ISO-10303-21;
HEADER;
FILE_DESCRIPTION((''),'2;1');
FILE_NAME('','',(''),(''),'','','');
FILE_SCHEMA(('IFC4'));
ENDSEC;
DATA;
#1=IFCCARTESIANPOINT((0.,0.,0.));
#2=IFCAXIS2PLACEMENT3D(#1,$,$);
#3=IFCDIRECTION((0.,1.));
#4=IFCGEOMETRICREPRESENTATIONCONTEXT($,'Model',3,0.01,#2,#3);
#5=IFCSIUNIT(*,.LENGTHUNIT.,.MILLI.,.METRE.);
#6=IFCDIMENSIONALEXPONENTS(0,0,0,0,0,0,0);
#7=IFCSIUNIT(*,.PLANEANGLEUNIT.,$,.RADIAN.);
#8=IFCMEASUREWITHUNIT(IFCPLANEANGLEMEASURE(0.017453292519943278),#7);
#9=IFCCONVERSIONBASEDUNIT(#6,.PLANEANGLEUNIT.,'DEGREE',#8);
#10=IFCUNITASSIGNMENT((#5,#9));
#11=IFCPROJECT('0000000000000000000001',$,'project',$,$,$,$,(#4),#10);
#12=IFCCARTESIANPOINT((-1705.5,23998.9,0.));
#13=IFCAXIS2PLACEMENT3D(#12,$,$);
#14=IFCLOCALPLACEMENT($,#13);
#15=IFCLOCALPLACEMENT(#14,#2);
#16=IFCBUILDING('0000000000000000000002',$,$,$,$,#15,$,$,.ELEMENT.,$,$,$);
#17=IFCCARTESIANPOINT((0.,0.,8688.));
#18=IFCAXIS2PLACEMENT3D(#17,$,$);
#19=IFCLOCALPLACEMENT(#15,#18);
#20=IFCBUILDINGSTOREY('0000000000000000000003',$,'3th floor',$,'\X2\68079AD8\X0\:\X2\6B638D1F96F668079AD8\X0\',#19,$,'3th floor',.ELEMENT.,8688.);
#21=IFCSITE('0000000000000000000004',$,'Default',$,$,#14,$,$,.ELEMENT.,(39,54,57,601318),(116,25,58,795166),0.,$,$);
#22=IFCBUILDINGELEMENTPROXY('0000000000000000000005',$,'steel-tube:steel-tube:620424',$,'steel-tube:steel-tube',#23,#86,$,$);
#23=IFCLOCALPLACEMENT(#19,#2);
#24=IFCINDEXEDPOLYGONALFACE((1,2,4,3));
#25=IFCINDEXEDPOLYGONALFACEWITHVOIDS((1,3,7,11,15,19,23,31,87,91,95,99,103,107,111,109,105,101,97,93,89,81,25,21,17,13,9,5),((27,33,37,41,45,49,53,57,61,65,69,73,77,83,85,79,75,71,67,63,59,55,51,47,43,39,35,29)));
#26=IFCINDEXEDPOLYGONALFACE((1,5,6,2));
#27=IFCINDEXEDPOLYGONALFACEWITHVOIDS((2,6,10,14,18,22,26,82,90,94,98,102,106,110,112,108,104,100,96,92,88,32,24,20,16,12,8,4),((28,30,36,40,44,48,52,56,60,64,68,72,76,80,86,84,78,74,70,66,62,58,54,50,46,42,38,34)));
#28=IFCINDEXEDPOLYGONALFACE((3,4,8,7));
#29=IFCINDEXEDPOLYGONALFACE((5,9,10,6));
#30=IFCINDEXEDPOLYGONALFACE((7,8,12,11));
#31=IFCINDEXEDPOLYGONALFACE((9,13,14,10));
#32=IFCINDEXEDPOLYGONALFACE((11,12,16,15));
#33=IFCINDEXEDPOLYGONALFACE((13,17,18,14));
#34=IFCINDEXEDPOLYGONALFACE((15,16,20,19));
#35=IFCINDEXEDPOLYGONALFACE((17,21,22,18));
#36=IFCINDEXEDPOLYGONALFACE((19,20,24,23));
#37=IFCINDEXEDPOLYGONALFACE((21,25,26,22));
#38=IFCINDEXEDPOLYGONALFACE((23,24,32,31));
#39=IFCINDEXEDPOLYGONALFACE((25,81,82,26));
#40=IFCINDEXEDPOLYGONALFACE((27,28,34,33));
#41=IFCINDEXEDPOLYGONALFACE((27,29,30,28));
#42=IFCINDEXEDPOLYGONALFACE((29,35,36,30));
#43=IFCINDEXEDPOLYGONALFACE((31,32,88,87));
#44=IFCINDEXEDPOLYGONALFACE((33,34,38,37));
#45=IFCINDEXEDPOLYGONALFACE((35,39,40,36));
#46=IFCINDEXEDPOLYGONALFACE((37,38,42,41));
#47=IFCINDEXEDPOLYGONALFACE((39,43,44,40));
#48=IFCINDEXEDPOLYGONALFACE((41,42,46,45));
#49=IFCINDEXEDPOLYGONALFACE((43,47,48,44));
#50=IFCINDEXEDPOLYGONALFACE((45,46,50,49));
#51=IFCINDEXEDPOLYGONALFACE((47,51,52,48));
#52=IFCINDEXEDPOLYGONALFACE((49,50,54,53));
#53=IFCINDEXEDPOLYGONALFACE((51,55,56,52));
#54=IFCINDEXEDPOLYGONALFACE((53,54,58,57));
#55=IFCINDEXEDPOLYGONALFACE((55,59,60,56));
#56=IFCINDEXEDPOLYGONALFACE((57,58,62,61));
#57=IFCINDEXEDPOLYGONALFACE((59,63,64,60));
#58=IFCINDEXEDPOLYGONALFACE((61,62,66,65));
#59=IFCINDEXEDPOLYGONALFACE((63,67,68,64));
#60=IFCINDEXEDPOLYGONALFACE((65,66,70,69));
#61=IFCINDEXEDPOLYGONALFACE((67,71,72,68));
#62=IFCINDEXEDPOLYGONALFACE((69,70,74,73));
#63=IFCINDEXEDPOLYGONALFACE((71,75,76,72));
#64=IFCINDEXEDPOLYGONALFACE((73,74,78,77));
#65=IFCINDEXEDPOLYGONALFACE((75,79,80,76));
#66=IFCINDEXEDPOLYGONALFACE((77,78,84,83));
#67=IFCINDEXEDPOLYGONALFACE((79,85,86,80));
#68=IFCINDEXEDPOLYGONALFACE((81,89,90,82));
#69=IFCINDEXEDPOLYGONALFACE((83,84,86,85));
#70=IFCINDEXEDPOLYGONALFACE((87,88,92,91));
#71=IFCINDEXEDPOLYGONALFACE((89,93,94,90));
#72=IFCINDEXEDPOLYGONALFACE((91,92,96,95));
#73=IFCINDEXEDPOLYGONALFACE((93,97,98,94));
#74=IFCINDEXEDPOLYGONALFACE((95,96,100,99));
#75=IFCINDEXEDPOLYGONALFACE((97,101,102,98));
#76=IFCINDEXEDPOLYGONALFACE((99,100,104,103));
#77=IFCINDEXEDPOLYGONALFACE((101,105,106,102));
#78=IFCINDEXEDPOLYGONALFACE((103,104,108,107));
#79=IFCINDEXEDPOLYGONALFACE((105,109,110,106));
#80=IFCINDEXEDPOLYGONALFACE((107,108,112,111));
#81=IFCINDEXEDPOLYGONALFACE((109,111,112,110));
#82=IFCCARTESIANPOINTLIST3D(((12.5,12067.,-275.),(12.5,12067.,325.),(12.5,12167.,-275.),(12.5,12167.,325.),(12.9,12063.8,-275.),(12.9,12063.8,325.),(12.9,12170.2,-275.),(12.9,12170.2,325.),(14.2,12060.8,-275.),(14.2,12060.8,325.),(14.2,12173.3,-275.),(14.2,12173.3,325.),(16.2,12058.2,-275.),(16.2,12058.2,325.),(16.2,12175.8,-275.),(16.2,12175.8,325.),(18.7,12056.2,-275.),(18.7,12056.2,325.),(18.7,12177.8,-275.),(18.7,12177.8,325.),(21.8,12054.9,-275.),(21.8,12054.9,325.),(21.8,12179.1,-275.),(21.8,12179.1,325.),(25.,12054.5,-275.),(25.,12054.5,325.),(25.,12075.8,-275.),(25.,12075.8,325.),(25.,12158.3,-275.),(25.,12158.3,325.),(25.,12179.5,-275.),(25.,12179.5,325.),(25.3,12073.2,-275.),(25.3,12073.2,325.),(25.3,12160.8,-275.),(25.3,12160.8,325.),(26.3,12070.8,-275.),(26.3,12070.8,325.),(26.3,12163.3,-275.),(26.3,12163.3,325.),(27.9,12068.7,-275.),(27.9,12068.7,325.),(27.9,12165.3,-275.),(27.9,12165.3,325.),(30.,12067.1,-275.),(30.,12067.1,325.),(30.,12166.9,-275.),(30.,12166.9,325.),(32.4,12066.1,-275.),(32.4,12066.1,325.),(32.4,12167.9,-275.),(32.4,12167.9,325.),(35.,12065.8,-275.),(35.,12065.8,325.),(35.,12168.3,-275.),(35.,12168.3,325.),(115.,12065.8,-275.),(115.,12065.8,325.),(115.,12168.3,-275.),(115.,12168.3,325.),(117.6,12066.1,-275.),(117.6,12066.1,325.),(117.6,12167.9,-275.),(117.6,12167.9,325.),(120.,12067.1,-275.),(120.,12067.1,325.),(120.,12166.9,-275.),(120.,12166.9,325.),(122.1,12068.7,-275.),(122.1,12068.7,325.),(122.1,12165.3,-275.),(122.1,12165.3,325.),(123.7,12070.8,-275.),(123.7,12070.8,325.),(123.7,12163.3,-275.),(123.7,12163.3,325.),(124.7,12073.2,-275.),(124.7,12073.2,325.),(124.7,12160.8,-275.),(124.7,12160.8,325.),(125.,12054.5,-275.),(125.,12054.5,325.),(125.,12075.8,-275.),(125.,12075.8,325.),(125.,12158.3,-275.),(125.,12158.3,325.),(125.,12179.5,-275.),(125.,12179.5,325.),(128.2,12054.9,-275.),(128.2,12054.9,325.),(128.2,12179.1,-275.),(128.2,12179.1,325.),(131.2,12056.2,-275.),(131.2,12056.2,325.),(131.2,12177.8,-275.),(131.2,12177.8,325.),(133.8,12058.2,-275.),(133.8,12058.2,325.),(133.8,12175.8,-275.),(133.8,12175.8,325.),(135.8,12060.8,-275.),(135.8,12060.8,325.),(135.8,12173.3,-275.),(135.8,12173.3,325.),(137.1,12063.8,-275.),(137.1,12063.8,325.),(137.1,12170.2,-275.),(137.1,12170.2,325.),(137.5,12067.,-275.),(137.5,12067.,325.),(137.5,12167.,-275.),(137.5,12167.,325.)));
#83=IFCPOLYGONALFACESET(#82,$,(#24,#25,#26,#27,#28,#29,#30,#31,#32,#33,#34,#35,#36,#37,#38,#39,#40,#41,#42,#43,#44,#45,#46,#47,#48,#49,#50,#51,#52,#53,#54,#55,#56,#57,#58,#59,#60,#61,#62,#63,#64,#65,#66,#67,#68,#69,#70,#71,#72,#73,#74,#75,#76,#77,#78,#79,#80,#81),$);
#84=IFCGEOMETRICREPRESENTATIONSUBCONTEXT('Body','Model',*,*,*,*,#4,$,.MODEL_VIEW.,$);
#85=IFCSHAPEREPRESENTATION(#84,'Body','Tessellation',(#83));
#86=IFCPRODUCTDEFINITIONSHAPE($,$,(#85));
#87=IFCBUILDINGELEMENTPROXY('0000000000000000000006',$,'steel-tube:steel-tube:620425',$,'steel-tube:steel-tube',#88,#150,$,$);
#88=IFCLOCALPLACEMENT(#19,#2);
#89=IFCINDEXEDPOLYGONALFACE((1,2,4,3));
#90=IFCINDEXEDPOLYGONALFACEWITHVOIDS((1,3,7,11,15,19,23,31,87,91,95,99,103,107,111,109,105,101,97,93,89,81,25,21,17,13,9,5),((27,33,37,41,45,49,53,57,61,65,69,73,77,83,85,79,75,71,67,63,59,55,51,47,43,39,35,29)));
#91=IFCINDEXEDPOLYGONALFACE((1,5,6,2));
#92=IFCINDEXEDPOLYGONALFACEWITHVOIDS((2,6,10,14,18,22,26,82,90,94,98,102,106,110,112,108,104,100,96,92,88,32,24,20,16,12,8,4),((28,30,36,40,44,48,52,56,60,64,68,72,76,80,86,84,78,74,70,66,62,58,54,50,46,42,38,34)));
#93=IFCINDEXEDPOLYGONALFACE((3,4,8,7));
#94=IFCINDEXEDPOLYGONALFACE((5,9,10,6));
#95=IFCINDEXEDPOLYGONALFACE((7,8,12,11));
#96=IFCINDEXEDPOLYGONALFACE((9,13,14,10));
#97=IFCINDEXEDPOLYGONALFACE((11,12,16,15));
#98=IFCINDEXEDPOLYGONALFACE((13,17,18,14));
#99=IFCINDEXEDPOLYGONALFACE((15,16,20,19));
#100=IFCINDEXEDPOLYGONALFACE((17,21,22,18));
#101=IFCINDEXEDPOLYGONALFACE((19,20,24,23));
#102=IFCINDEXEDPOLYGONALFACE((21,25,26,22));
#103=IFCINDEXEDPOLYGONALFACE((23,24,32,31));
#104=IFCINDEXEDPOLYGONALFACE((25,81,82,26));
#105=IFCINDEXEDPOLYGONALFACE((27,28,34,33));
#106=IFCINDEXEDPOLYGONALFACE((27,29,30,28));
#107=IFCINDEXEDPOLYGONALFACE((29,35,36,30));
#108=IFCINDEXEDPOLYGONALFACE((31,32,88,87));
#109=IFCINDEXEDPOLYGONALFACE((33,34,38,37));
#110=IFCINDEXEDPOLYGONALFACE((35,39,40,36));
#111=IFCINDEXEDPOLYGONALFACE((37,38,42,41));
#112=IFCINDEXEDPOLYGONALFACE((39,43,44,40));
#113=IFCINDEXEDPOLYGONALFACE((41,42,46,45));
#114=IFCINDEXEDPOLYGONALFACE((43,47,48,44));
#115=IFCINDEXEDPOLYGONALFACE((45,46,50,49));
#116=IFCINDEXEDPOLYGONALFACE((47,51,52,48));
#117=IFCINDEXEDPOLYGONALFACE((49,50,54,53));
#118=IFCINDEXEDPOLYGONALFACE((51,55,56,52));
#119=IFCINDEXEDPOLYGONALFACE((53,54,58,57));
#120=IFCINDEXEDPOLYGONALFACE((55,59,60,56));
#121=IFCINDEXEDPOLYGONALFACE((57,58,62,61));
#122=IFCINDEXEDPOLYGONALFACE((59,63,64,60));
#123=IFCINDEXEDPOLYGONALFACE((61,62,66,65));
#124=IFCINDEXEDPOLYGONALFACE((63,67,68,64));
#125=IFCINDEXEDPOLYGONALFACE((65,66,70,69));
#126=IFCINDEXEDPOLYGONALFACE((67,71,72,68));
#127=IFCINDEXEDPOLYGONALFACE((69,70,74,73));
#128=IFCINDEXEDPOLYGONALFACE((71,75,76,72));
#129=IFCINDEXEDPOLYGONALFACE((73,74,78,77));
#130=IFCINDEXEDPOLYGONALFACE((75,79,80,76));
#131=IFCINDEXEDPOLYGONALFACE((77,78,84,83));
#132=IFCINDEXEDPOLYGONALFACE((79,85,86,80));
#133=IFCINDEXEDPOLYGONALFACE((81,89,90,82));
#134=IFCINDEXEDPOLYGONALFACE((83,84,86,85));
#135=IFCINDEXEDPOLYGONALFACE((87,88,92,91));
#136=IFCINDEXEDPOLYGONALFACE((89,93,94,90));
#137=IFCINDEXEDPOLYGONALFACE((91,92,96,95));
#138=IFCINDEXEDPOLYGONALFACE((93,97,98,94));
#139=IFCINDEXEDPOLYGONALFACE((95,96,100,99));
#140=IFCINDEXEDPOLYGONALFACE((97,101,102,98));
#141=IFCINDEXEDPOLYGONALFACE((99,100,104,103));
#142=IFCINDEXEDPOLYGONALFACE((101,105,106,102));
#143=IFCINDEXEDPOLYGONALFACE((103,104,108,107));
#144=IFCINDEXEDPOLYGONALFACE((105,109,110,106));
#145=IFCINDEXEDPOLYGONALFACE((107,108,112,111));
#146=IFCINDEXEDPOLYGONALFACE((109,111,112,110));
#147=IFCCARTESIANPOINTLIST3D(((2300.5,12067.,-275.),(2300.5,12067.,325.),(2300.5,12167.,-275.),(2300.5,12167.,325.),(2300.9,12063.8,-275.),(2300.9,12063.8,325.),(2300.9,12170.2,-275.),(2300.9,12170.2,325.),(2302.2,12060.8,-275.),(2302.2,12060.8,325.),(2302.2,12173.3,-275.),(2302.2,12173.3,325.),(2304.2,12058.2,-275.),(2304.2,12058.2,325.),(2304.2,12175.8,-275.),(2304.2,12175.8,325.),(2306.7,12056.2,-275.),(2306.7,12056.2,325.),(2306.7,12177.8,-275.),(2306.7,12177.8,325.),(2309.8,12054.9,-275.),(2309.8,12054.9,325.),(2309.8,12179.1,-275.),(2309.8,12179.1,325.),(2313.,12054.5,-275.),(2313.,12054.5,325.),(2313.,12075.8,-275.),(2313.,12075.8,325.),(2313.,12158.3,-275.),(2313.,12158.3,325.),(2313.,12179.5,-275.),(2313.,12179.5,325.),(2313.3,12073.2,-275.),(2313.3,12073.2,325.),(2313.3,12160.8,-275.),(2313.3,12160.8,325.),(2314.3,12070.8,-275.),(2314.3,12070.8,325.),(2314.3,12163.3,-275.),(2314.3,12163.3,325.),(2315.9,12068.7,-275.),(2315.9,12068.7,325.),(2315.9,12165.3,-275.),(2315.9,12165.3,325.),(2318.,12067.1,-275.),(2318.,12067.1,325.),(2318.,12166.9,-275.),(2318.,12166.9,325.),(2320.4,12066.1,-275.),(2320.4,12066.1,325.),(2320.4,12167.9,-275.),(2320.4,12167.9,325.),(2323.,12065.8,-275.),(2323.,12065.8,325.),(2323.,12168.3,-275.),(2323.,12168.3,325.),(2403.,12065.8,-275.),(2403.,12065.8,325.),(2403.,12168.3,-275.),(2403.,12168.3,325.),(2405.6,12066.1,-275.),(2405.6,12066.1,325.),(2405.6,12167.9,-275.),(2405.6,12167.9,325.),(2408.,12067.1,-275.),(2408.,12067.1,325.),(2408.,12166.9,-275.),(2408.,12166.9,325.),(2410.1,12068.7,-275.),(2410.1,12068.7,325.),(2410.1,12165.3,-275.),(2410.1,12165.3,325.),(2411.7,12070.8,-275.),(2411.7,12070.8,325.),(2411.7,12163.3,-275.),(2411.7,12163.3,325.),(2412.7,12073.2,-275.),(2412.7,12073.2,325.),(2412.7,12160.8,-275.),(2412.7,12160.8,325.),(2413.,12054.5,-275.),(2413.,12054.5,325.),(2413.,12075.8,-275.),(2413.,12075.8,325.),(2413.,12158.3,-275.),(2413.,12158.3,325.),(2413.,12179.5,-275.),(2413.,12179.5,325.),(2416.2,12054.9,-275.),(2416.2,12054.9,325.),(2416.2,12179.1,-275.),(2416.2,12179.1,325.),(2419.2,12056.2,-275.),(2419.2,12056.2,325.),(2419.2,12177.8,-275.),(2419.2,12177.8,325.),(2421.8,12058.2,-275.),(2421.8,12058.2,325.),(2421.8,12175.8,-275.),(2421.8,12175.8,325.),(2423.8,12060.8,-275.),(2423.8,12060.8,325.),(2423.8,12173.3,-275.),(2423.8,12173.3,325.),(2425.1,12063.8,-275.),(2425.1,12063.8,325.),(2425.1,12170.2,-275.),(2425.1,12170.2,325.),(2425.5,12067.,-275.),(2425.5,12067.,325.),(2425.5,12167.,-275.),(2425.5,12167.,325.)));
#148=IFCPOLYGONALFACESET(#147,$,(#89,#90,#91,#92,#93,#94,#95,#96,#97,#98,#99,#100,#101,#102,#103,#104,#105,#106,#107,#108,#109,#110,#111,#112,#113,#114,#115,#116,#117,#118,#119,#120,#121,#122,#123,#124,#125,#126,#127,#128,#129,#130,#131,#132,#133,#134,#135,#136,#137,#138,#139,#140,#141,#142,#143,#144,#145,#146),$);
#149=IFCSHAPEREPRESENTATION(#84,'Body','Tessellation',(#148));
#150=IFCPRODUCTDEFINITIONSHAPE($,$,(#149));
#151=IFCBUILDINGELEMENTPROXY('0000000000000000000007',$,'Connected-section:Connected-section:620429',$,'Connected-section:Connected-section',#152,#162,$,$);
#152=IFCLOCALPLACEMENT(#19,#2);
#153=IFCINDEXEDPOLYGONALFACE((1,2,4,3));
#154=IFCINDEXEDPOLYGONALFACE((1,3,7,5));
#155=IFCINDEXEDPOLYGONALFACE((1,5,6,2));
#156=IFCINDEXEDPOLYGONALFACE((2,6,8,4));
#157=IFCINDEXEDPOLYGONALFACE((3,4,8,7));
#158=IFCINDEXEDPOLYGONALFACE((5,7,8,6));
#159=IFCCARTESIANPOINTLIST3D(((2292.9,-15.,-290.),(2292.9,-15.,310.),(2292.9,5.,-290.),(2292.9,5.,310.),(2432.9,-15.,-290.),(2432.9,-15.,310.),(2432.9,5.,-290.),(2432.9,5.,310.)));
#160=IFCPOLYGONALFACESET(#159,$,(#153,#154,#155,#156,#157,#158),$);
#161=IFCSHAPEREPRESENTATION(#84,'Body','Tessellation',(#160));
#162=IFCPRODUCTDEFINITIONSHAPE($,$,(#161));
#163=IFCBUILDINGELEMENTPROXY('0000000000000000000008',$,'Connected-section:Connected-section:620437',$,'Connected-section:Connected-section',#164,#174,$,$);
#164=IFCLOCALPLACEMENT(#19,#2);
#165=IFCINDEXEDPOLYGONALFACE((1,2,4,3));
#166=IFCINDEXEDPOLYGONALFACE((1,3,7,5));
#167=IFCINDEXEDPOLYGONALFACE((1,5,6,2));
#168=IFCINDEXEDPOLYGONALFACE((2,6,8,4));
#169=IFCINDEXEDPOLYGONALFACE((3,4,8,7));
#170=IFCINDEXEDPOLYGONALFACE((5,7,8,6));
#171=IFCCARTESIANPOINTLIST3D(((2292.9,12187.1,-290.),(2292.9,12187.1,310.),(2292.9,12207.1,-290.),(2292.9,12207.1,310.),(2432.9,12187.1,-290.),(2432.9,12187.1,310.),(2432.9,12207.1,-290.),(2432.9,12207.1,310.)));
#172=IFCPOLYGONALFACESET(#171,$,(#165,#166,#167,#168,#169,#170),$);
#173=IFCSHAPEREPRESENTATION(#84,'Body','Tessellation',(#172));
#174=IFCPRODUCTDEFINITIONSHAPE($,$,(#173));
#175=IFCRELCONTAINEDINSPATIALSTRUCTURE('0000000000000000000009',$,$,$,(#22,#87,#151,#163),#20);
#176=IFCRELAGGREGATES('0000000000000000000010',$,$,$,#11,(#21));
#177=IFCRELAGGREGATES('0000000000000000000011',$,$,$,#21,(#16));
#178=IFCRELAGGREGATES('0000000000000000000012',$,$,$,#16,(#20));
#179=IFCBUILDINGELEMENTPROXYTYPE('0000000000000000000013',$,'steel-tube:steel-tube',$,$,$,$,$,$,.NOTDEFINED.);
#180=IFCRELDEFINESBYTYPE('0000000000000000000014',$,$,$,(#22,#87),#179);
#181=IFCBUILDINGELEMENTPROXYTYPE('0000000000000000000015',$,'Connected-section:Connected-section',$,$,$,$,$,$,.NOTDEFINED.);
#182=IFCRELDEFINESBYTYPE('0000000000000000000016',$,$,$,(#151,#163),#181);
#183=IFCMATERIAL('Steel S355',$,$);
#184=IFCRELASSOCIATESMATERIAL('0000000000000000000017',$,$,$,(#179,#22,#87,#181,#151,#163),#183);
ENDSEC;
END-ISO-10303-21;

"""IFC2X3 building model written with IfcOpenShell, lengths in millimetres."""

from ifc_helpers import new_model, entity, si_unit, converted_unit, direction, frame, frame_2d, origin, place, context, subcontext, project, spatial, polyline, circle_curve, parameter, trimmed, segment, composite_curve, rectangle, outline, extrude, source, transform, mapped, material, type_object, type_shapes, element, save


model = new_model("IFC2X3")

# Units and contexts
model_context = context("Model", 3, precision=0.01, world=origin(), true_north=direction((0.0, 1.0)))
body_context = subcontext(model_context, "Body", "Model", "MODEL_VIEW")
ifc_project = project(units=[si_unit("LENGTHUNIT", "METRE", prefix="MILLI"), converted_unit("PLANEANGLEUNIT", "DEGREE", entity("IfcPlaneAngleMeasure", 0.017453292519943278), si_unit("PLANEANGLEUNIT", "RADIAN"), dimensions=[0, 0, 0, 0, 0, 0, 0])], contexts=[model_context])

# Site, building, storey
site_placement = place(None, frame((-1705.5, 23998.9, 0.0)))
site = spatial("IfcSite", under=ifc_project, at=site_placement, Name="Default", CompositionType="ELEMENT", RefLatitude=(39, 54, 57, 601318), RefLongitude=(116, 25, 58, 795166), RefElevation=0.0)
building_placement = place(site_placement, origin())
building = spatial("IfcBuilding", under=site, at=building_placement, CompositionType="ELEMENT")
storey_placement = place(building_placement, frame((0.0, 0.0, 8688.0)))
storey = spatial("IfcBuildingStorey", under=building, at=storey_placement, Name="3th floor", ObjectType="标高:正负零标高", LongName="3th floor", CompositionType="ELEMENT", Elevation=8688.0)

# Shared definitions
ifc_material_1 = material(Name="Steel S355")

# Building element proxies
building_element_proxy_type_1 = type_object("IfcBuildingElementProxyType", Name="steel-tube:steel-tube", PredefinedType="NOTDEFINED", material=ifc_material_1)
shared_shape_1 = source(origin(), body_context, "Body", "SweptSolid", [
    extrude(outline(composite_curve([segment(trimmed(circle_curve(frame_2d((50.0, -50.0), x_axis=(1.0, 0.0)), 12.5), [parameter(270.0)], [parameter(0.0)], True, "PARAMETER"), True, "CONTINUOUS"), segment(polyline([(62.5, -50.0), (62.5, 50.0)]), True, "CONTINUOUS"), segment(trimmed(circle_curve(frame_2d((50.0, 50.0), x_axis=(1.0, 0.0)), 12.5), [parameter(0.0)], [parameter(90.0)], True, "PARAMETER"), True, "CONTINUOUS"), segment(polyline([(50.0, 62.5), (-50.0, 62.5)]), True, "CONTINUOUS"), segment(trimmed(circle_curve(frame_2d((-50.0, 50.0), x_axis=(1.0, 0.0)), 12.5), [parameter(90.0)], [parameter(180.0)], True, "PARAMETER"), True, "CONTINUOUS"), segment(polyline([(-62.5, 50.0), (-62.5, -50.0)]), True, "CONTINUOUS"), segment(trimmed(circle_curve(frame_2d((-50.0, -50.0), x_axis=(1.0, 0.0)), 12.5), [parameter(180.0)], [parameter(270.0)], True, "PARAMETER"), True, "CONTINUOUS"), segment(polyline([(-50.0, -62.5), (50.0, -62.5)]), True, "CONTINUOUS")], self_intersect=False), holes=[composite_curve([segment(trimmed(circle_curve(frame_2d((-41.2, 40.0), x_axis=(1.0, 0.0)), 10.0), [parameter(90.0)], [parameter(180.0)], True, "PARAMETER"), False, "CONTINUOUS"), segment(polyline([(-41.3, 50.0), (41.2, 50.0)]), True, "CONTINUOUS"), segment(trimmed(circle_curve(frame_2d((41.2, 40.0), x_axis=(1.0, 0.0)), 10.0), [parameter(0.0)], [parameter(90.0)], True, "PARAMETER"), False, "CONTINUOUS"), segment(polyline([(51.2, 40.0), (51.2, -40.0)]), True, "CONTINUOUS"), segment(trimmed(circle_curve(frame_2d((41.2, -40.0), x_axis=(1.0, 0.0)), 10.0), [parameter(270.0)], [parameter(360.0)], True, "PARAMETER"), False, "CONTINUOUS"), segment(polyline([(41.2, -50.0), (-41.3, -50.0)]), True, "CONTINUOUS"), segment(trimmed(circle_curve(frame_2d((-41.3, -40.0), x_axis=(1.0, 0.0)), 10.0), [parameter(180.0)], [parameter(270.0)], True, "PARAMETER"), False, "CONTINUOUS"), segment(polyline([(-51.3, -40.0), (-51.3, 40.0)]), True, "CONTINUOUS")], self_intersect=False)]), frame((62.5, 62.5, -175.0)), (0.0, 0.0, 1.0), 600.0),
])
type_shapes(building_element_proxy_type_1, [shared_shape_1])
for number, where, z_axis, x_axis, name in (
    (1, (12.5, 12179.5, -100.0), (0.0, 0.0, 1.0), (0.0, -1.0, 0.0), "steel-tube:steel-tube:620424"),
    (2, (2300.5, 12179.5, -100.0), (0.0, 0.0, 1.0), (0.0, -1.0, 0.0), "steel-tube:steel-tube:620425"),
):
    element("IfcBuildingElementProxy", number, at=place(storey_placement, frame(where, z_axis=z_axis, x_axis=x_axis)), inside=storey, type_object=building_element_proxy_type_1, material=ifc_material_1, Name=name, ObjectType="steel-tube:steel-tube", context=body_context, shape_type="MappedRepresentation", body=[
        mapped(shared_shape_1, transform((0.0, 0.0, 0.0), scale=1.0)),
    ])
building_element_proxy_type_2 = type_object("IfcBuildingElementProxyType", Name="Connected-section:Connected-section", PredefinedType="NOTDEFINED", material=ifc_material_1)
shared_shape_2 = source(origin(), body_context, "Body", "SweptSolid", [
    extrude(rectangle(XDim=20.0, YDim=140.0, at=frame_2d((0.0, 0.0), x_axis=(1.0, 0.0))), frame((70.0, 10.0, 0.0), z_axis=(0.0, 0.0, 1.0), x_axis=(0.0, 1.0, 0.0)), (0.0, 0.0, 1.0), 600.0),
])
type_shapes(building_element_proxy_type_2, [shared_shape_2])
for number, where, name in (
    (3, (2292.9, -15.0, -290.0), "Connected-section:Connected-section:620429"),
    (4, (2292.9, 12187.1, -290.0), "Connected-section:Connected-section:620437"),
):
    element("IfcBuildingElementProxy", number, at=place(storey_placement, frame(where)), inside=storey, type_object=building_element_proxy_type_2, material=ifc_material_1, Name=name, ObjectType="Connected-section:Connected-section", context=body_context, shape_type="MappedRepresentation", body=[
        mapped(shared_shape_2, transform((0.0, 0.0, 0.0), scale=1.0)),
    ])

save(model, "model.ifc")
